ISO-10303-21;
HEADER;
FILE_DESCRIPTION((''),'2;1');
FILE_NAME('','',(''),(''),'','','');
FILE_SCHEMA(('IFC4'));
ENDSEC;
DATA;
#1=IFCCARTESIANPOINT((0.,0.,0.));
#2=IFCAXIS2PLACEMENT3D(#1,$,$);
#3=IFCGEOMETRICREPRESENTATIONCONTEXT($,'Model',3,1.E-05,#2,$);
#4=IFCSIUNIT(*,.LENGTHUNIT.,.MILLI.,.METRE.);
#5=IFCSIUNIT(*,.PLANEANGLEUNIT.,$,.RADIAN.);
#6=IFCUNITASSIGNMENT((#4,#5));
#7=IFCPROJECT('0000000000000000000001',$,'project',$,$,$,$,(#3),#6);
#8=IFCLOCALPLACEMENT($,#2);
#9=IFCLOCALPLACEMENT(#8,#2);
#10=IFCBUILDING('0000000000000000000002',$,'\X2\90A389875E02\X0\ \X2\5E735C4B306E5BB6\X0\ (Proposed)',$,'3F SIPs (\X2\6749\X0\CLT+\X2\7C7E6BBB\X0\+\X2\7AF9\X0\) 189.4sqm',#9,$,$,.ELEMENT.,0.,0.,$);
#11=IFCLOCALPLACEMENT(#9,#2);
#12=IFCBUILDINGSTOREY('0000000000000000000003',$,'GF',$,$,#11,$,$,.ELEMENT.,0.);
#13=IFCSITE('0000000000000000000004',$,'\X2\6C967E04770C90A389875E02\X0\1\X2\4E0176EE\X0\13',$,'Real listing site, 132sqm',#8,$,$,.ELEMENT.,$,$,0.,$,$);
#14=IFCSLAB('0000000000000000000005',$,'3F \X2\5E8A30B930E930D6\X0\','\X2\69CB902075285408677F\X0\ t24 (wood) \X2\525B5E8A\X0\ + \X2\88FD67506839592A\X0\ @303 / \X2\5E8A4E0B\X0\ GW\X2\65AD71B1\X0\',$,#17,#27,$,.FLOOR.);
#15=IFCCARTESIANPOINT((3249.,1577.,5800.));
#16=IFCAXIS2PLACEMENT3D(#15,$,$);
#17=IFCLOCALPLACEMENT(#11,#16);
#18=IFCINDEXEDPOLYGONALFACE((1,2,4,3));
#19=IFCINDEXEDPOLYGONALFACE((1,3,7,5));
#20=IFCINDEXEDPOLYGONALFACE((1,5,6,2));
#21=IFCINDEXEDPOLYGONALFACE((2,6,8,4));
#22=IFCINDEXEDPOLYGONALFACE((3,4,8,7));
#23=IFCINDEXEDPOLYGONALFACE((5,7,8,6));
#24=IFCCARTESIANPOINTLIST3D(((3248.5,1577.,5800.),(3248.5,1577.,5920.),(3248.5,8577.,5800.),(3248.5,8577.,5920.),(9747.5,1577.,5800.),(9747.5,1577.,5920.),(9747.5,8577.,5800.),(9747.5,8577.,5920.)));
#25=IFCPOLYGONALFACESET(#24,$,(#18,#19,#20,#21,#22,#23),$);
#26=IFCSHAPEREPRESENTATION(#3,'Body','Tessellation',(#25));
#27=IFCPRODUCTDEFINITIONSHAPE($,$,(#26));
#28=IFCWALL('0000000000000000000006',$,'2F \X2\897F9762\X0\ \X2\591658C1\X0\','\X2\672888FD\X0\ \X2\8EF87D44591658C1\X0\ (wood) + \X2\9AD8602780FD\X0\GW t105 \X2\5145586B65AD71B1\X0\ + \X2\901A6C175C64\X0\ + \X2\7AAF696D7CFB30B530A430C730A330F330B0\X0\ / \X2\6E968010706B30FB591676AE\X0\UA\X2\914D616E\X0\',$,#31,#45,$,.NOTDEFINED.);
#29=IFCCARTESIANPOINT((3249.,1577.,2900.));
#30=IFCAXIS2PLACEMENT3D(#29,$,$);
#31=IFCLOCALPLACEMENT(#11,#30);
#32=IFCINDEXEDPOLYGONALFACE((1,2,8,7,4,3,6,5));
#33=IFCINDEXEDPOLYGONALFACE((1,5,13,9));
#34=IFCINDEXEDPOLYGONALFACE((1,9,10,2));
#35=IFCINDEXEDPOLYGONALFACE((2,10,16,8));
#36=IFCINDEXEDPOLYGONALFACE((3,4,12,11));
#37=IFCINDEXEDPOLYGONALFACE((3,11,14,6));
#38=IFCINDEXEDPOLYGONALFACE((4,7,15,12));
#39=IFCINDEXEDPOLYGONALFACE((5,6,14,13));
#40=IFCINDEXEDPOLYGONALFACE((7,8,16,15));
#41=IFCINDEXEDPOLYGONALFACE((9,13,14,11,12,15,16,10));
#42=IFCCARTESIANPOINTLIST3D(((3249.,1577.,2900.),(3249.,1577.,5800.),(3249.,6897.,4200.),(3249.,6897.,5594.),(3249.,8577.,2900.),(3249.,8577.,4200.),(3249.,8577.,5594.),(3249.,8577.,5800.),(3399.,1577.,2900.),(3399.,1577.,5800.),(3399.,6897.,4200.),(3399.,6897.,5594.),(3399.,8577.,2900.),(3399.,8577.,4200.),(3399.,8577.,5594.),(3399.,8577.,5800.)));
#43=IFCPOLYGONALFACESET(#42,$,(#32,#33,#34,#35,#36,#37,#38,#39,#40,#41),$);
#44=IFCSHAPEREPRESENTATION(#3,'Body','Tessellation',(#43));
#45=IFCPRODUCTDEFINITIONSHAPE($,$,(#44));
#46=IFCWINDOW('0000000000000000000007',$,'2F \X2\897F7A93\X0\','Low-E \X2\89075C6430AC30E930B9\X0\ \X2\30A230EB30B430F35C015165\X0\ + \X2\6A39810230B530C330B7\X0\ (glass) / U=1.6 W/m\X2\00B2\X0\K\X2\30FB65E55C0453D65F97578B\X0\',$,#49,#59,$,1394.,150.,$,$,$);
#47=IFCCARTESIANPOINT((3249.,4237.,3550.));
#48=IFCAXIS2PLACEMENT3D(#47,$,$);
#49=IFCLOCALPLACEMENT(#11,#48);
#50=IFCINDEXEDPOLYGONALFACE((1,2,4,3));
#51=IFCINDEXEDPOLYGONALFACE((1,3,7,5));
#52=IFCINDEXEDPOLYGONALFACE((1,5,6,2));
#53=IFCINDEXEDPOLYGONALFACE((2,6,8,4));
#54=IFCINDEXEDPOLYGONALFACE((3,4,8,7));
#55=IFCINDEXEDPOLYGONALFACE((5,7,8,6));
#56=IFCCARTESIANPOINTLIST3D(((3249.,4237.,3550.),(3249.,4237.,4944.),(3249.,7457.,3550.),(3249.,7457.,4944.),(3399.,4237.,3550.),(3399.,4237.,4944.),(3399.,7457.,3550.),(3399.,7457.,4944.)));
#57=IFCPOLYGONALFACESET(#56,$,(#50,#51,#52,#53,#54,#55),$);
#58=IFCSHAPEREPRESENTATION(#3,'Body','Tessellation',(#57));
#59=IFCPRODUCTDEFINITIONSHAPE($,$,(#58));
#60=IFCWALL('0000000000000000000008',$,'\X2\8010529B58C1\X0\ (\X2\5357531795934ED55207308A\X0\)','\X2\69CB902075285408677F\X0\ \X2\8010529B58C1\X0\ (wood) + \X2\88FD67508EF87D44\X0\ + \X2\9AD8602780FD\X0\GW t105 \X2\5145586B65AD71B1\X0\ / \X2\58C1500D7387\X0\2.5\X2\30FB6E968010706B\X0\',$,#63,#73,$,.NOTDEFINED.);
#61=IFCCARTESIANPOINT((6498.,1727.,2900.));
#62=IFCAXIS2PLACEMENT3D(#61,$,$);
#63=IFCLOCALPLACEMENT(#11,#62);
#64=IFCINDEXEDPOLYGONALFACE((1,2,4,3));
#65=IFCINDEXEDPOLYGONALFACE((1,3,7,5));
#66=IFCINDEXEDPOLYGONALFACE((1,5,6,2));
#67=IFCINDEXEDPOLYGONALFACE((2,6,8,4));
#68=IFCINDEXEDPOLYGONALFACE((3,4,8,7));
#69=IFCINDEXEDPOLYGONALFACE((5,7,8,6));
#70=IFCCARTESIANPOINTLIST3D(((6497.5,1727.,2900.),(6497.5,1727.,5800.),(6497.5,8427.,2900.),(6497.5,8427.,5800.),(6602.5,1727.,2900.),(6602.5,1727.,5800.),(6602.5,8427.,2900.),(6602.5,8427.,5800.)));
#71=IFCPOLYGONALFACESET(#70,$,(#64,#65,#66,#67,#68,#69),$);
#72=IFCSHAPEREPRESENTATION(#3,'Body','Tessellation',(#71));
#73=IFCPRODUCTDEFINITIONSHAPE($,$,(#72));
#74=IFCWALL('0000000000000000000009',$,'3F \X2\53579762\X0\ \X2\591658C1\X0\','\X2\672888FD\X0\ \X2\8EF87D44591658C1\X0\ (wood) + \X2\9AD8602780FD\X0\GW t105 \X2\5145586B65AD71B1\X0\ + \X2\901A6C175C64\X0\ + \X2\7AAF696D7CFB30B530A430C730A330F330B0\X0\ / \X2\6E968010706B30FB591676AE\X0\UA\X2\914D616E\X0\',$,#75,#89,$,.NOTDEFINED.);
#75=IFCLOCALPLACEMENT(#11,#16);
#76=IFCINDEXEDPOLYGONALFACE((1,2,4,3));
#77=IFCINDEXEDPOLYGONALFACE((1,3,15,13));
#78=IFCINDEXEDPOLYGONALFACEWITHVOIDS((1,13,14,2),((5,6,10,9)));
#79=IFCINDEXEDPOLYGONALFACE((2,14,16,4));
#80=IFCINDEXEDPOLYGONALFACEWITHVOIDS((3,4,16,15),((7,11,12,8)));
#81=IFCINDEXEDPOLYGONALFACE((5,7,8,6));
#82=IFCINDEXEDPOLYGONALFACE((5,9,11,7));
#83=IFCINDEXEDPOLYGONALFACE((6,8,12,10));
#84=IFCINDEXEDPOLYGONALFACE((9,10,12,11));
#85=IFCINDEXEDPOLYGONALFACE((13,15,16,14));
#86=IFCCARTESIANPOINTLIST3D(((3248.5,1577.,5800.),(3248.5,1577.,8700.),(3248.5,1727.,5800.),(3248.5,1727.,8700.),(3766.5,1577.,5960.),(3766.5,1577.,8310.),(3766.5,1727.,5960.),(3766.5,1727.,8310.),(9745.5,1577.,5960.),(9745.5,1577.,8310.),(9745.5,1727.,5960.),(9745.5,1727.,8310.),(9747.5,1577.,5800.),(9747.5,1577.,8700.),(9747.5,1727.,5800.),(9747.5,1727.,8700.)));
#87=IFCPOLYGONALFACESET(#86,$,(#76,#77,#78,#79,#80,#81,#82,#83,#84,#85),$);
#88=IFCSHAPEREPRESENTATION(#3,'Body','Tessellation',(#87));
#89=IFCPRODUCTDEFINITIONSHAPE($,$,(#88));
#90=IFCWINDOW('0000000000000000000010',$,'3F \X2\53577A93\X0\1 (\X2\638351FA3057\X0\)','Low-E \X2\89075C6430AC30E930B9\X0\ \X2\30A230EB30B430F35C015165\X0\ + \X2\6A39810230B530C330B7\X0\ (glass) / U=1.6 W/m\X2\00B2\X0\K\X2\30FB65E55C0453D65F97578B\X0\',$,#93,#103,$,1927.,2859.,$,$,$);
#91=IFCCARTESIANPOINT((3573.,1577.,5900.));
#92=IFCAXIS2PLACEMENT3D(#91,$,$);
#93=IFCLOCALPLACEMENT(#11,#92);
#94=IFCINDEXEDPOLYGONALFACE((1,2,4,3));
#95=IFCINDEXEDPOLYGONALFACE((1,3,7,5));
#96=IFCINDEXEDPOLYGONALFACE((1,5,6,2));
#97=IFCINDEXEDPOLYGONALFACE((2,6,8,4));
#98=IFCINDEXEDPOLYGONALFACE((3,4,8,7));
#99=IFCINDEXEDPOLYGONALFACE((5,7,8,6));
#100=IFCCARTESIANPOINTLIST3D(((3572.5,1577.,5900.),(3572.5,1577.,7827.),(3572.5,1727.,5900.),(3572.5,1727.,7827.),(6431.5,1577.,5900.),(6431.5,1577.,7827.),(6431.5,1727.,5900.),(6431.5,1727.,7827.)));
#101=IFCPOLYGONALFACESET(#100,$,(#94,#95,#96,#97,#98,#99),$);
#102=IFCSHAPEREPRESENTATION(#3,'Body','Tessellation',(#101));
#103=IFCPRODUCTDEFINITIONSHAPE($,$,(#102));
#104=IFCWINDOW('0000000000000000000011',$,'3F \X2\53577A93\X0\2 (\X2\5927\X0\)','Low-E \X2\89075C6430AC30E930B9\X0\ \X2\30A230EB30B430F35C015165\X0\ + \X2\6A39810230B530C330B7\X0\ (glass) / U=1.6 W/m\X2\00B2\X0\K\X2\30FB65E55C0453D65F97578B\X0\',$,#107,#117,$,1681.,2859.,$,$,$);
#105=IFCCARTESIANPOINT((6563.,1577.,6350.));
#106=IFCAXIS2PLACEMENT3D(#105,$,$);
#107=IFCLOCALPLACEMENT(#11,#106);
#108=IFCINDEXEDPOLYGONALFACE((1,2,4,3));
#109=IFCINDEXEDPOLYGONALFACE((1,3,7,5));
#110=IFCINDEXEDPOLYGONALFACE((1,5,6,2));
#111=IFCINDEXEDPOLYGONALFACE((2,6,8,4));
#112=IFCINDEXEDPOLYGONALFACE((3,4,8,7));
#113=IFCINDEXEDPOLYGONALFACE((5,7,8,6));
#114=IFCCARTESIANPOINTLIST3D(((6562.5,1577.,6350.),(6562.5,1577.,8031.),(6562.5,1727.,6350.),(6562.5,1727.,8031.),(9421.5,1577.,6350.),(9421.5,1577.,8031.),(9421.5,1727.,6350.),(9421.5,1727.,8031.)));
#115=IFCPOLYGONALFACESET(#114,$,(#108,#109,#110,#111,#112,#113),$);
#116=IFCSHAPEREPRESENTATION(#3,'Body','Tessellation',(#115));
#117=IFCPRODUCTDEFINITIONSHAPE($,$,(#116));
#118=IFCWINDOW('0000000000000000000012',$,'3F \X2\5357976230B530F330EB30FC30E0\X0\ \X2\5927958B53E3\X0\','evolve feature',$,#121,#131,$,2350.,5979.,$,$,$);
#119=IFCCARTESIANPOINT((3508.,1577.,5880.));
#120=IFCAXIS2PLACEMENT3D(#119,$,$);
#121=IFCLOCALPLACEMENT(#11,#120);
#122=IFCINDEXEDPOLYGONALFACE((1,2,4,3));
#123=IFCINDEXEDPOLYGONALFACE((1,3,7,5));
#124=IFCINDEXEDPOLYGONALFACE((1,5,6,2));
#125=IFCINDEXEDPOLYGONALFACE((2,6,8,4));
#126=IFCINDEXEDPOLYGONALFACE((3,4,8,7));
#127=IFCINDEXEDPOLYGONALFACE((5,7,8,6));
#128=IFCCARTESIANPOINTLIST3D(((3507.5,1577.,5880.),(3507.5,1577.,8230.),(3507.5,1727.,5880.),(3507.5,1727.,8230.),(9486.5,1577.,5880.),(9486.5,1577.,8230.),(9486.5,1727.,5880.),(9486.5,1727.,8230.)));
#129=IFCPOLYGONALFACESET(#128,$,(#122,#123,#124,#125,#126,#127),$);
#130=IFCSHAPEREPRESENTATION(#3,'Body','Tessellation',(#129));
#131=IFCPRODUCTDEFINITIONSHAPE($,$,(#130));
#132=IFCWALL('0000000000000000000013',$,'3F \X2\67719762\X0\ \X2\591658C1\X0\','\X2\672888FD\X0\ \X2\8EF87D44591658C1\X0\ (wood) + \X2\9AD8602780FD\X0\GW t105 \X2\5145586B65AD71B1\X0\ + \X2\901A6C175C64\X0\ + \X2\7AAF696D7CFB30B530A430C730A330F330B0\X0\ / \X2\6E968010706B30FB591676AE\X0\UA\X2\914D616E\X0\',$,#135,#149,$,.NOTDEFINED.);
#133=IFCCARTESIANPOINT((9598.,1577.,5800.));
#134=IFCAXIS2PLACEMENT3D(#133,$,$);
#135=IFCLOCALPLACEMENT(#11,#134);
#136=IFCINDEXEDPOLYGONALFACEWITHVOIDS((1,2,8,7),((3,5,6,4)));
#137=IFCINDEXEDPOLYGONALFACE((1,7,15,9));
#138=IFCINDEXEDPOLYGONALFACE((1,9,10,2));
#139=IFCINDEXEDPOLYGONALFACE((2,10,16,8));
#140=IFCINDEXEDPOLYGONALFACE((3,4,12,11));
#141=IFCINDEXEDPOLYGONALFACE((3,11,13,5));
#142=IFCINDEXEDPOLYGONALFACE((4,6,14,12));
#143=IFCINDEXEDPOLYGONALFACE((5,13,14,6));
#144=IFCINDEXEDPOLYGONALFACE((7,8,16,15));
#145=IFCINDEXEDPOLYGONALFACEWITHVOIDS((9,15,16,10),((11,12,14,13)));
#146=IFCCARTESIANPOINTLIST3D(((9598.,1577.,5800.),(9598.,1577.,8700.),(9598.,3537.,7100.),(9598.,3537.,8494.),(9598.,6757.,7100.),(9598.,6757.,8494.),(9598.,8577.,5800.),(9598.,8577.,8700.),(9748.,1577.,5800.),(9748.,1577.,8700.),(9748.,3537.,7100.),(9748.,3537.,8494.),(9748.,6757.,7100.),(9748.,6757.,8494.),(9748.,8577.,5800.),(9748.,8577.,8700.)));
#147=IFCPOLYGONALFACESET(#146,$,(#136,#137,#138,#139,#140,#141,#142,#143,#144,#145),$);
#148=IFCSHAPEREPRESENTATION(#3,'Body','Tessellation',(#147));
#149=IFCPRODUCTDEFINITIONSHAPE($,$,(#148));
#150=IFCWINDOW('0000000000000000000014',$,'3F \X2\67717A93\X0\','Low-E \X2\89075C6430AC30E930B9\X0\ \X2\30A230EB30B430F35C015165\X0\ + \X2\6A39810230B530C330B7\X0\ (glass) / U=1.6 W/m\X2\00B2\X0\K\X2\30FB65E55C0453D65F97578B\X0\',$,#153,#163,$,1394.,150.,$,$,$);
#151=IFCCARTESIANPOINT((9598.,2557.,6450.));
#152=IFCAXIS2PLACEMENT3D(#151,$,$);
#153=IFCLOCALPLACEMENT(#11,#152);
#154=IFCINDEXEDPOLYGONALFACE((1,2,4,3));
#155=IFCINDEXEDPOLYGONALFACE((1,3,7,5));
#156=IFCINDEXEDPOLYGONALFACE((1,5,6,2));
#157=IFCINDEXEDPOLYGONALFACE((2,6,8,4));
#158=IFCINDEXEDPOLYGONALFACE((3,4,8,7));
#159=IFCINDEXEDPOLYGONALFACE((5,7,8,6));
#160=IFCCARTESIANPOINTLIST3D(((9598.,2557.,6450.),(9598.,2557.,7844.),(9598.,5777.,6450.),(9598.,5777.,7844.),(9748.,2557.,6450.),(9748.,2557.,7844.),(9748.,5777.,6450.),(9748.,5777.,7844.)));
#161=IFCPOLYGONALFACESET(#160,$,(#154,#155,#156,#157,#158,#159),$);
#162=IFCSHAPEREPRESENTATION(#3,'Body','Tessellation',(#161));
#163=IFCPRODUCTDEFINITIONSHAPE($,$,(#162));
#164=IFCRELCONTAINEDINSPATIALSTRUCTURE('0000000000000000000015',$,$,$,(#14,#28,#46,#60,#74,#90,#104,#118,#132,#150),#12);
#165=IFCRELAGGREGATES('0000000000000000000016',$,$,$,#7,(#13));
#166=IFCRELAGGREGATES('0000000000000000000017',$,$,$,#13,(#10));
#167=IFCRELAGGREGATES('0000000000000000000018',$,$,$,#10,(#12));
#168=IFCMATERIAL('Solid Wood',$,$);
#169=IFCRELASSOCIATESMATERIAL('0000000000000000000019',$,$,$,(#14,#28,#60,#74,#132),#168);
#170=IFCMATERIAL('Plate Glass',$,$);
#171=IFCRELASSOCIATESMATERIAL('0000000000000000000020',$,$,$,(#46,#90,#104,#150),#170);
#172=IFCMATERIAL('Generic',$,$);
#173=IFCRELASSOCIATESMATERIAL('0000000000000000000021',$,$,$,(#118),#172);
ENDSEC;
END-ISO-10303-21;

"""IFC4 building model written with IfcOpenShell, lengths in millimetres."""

from ifc_helpers import new_model, si_unit, frame, frame_2d, origin, place, context, project, spatial, rectangle, extrude, material, element, fill, save


model = new_model("IFC4")

# Units and contexts
model_context = context("Model", 3, precision=1e-05, world=origin())
ifc_project = project(units=[si_unit("LENGTHUNIT", "METRE", prefix="MILLI"), si_unit("PLANEANGLEUNIT", "RADIAN")], contexts=[model_context])

# Site, building, storey
site_placement = place(None, origin())
site = spatial("IfcSite", under=ifc_project, at=site_placement, Name="沖縄県那覇市1丁目13", ObjectType="Real listing site, 132sqm", CompositionType="ELEMENT", RefElevation=0.0)
building_placement = place(site_placement, origin())
building = spatial("IfcBuilding", under=site, at=building_placement, Name="那覇市 平屋の家 (Proposed)", ObjectType="3F SIPs (杉CLT+籾殻+竹) 189.4sqm", CompositionType="ELEMENT", ElevationOfRefHeight=0.0, ElevationOfTerrain=0.0)
storey_placement = place(building_placement, origin())
storey = spatial("IfcBuildingStorey", under=building, at=storey_placement, Name="GF", CompositionType="ELEMENT", Elevation=0.0)

# Slab
ifc_material_1 = material(Name="Solid Wood")
slab_placement = place(storey_placement, frame((3249.0, 1577.0, 5800.0)))
element("IfcSlab", 1, at=slab_placement, inside=storey, material=ifc_material_1, Name="3F 床スラブ", Description="構造用合板 t24 (wood) 剛床 + 製材根太 @303 / 床下 GW断熱", PredefinedType="FLOOR", context=model_context, shape_type="SweptSolid", body=[
    extrude(rectangle(XDim=6499.0, YDim=7000.0, at=frame_2d((3249.0, 3500.0))), frame((3249.0, 1577.0, 5800.0)), (0.0, 0.0, 1.0), 120.0),
])

# Wall, opening, window
wall_1_placement = place(storey_placement, frame((3249.0, 1577.0, 2900.0)))
wall_1 = element("IfcWall", 2, at=wall_1_placement, inside=storey, material=ifc_material_1, Name="2F 西面 外壁", Description="木製 軸組外壁 (wood) + 高性能GW t105 充填断熱 + 通気層 + 窯業系サイディング / 準耐火・外皮UA配慮", PredefinedType="NOTDEFINED", context=model_context, shape_type="SweptSolid", body=[
    extrude(rectangle(XDim=150.0, YDim=7000.0, at=frame_2d((75.0, 3500.0))), frame((3249.0, 1577.0, 2900.0)), (0.0, 0.0, 1.0), 2900.0),
])
opening_1_placement = place(storey_placement, frame((3249.0, 4237.0, 3550.0)))
opening_1 = element("IfcOpeningElement", 3, at=opening_1_placement, cuts=wall_1, PredefinedType="NOTDEFINED", context=model_context, shape_type="SweptSolid", body=[
    extrude(rectangle(XDim=150.0, YDim=3220.0, at=frame_2d((75.0, 1610.0))), frame((3249.0, 4237.0, 3550.0)), (0.0, 0.0, 1.0), 1394.0),
])
ifc_material_2 = material(Name="Plate Glass")
window_1_placement = place(storey_placement, frame((3249.0, 4237.0, 3550.0)))
window_1 = element("IfcWindow", 4, at=window_1_placement, inside=storey, material=ifc_material_2, Name="2F 西窓", Description="Low-E 複層ガラス アルゴン封入 + 樹脂サッシ (glass) / U=1.6 W/m²K・日射取得型", OverallHeight=1394.0, OverallWidth=150.0, context=model_context, shape_type="SweptSolid", body=[
    extrude(rectangle(XDim=150.0, YDim=3220.0, at=frame_2d((75.0, 1610.0))), frame((3249.0, 4237.0, 3550.0)), (0.0, 0.0, 1.0), 1394.0),
])
fill(opening_1, window_1)

# Wall
wall_2_placement = place(storey_placement, frame((6498.0, 1727.0, 2900.0)))
element("IfcWall", 5, at=wall_2_placement, inside=storey, material=ifc_material_1, Name="耐力壁 (南北間仕切り)", Description="構造用合板 耐力壁 (wood) + 製材軸組 + 高性能GW t105 充填断熱 / 壁倍率2.5・準耐火", PredefinedType="NOTDEFINED", context=model_context, shape_type="SweptSolid", body=[
    extrude(rectangle(XDim=105.0, YDim=6700.0, at=frame_2d((52.0, 3350.0))), frame((6498.0, 1727.0, 2900.0)), (0.0, 0.0, 1.0), 2900.0),
])

# Wall, openings, windows
wall_3_placement = place(storey_placement, frame((3249.0, 1577.0, 5800.0)))
wall_3 = element("IfcWall", 6, at=wall_3_placement, inside=storey, material=ifc_material_1, Name="3F 南面 外壁", Description="木製 軸組外壁 (wood) + 高性能GW t105 充填断熱 + 通気層 + 窯業系サイディング / 準耐火・外皮UA配慮", PredefinedType="NOTDEFINED", context=model_context, shape_type="SweptSolid", body=[
    extrude(rectangle(XDim=6499.0, YDim=150.0, at=frame_2d((3249.0, 75.0))), frame((3249.0, 1577.0, 5800.0)), (0.0, 0.0, 1.0), 2900.0),
])
opening_2_placement = place(storey_placement, frame((3573.0, 1577.0, 5900.0)))
opening_2 = element("IfcOpeningElement", 7, at=opening_2_placement, cuts=wall_3, PredefinedType="NOTDEFINED", context=model_context, shape_type="SweptSolid", body=[
    extrude(rectangle(XDim=2859.0, YDim=150.0, at=frame_2d((1429.0, 75.0))), frame((3573.0, 1577.0, 5900.0)), (0.0, 0.0, 1.0), 1927.0),
])
opening_3_placement = place(storey_placement, frame((6563.0, 1577.0, 6350.0)))
opening_3 = element("IfcOpeningElement", 8, at=opening_3_placement, cuts=wall_3, PredefinedType="NOTDEFINED", context=model_context, shape_type="SweptSolid", body=[
    extrude(rectangle(XDim=2859.0, YDim=150.0, at=frame_2d((1429.0, 75.0))), frame((6563.0, 1577.0, 6350.0)), (0.0, 0.0, 1.0), 1681.0),
])
opening_4_placement = place(storey_placement, frame((3508.0, 1577.0, 5880.0)))
opening_4 = element("IfcOpeningElement", 9, at=opening_4_placement, cuts=wall_3, PredefinedType="NOTDEFINED", context=model_context, shape_type="SweptSolid", body=[
    extrude(rectangle(XDim=5979.0, YDim=150.0, at=frame_2d((2989.0, 75.0))), frame((3508.0, 1577.0, 5880.0)), (0.0, 0.0, 1.0), 2350.0),
])
window_2_placement = place(storey_placement, frame((3573.0, 1577.0, 5900.0)))
window_2 = element("IfcWindow", 10, at=window_2_placement, inside=storey, material=ifc_material_2, Name="3F 南窓1 (掃出し)", Description="Low-E 複層ガラス アルゴン封入 + 樹脂サッシ (glass) / U=1.6 W/m²K・日射取得型", OverallHeight=1927.0, OverallWidth=2859.0, context=model_context, shape_type="SweptSolid", body=[
    extrude(rectangle(XDim=2859.0, YDim=150.0, at=frame_2d((1429.0, 75.0))), frame((3573.0, 1577.0, 5900.0)), (0.0, 0.0, 1.0), 1927.0),
])
fill(opening_2, window_2)
window_3_placement = place(storey_placement, frame((6563.0, 1577.0, 6350.0)))
window_3 = element("IfcWindow", 11, at=window_3_placement, inside=storey, material=ifc_material_2, Name="3F 南窓2 (大)", Description="Low-E 複層ガラス アルゴン封入 + 樹脂サッシ (glass) / U=1.6 W/m²K・日射取得型", OverallHeight=1681.0, OverallWidth=2859.0, context=model_context, shape_type="SweptSolid", body=[
    extrude(rectangle(XDim=2859.0, YDim=150.0, at=frame_2d((1429.0, 75.0))), frame((6563.0, 1577.0, 6350.0)), (0.0, 0.0, 1.0), 1681.0),
])
fill(opening_3, window_3)
ifc_material_3 = material(Name="Generic")
window_4_placement = place(storey_placement, frame((3508.0, 1577.0, 5880.0)))
window_4 = element("IfcWindow", 12, at=window_4_placement, inside=storey, material=ifc_material_3, Name="3F 南面サンルーム 大開口", Description="evolve feature", OverallHeight=2350.0, OverallWidth=5979.0, context=model_context, shape_type="SweptSolid", body=[
    extrude(rectangle(XDim=5979.0, YDim=150.0, at=frame_2d((2989.0, 75.0))), frame((3508.0, 1577.0, 5880.0)), (0.0, 0.0, 1.0), 2350.0),
])
fill(opening_4, window_4)

# Wall, opening, window
wall_4_placement = place(storey_placement, frame((9598.0, 1577.0, 5800.0)))
wall_4 = element("IfcWall", 13, at=wall_4_placement, inside=storey, material=ifc_material_1, Name="3F 東面 外壁", Description="木製 軸組外壁 (wood) + 高性能GW t105 充填断熱 + 通気層 + 窯業系サイディング / 準耐火・外皮UA配慮", PredefinedType="NOTDEFINED", context=model_context, shape_type="SweptSolid", body=[
    extrude(rectangle(XDim=150.0, YDim=7000.0, at=frame_2d((75.0, 3500.0))), frame((9598.0, 1577.0, 5800.0)), (0.0, 0.0, 1.0), 2900.0),
])
opening_5_placement = place(storey_placement, frame((9598.0, 2557.0, 6450.0)))
opening_5 = element("IfcOpeningElement", 14, at=opening_5_placement, cuts=wall_4, PredefinedType="NOTDEFINED", context=model_context, shape_type="SweptSolid", body=[
    extrude(rectangle(XDim=150.0, YDim=3220.0, at=frame_2d((75.0, 1610.0))), frame((9598.0, 2557.0, 6450.0)), (0.0, 0.0, 1.0), 1394.0),
])
window_5_placement = place(storey_placement, frame((9598.0, 2557.0, 6450.0)))
window_5 = element("IfcWindow", 15, at=window_5_placement, inside=storey, material=ifc_material_2, Name="3F 東窓", Description="Low-E 複層ガラス アルゴン封入 + 樹脂サッシ (glass) / U=1.6 W/m²K・日射取得型", OverallHeight=1394.0, OverallWidth=150.0, context=model_context, shape_type="SweptSolid", body=[
    extrude(rectangle(XDim=150.0, YDim=3220.0, at=frame_2d((75.0, 1610.0))), frame((9598.0, 2557.0, 6450.0)), (0.0, 0.0, 1.0), 1394.0),
])
fill(opening_5, window_5)

save(model, "model.ifc")
